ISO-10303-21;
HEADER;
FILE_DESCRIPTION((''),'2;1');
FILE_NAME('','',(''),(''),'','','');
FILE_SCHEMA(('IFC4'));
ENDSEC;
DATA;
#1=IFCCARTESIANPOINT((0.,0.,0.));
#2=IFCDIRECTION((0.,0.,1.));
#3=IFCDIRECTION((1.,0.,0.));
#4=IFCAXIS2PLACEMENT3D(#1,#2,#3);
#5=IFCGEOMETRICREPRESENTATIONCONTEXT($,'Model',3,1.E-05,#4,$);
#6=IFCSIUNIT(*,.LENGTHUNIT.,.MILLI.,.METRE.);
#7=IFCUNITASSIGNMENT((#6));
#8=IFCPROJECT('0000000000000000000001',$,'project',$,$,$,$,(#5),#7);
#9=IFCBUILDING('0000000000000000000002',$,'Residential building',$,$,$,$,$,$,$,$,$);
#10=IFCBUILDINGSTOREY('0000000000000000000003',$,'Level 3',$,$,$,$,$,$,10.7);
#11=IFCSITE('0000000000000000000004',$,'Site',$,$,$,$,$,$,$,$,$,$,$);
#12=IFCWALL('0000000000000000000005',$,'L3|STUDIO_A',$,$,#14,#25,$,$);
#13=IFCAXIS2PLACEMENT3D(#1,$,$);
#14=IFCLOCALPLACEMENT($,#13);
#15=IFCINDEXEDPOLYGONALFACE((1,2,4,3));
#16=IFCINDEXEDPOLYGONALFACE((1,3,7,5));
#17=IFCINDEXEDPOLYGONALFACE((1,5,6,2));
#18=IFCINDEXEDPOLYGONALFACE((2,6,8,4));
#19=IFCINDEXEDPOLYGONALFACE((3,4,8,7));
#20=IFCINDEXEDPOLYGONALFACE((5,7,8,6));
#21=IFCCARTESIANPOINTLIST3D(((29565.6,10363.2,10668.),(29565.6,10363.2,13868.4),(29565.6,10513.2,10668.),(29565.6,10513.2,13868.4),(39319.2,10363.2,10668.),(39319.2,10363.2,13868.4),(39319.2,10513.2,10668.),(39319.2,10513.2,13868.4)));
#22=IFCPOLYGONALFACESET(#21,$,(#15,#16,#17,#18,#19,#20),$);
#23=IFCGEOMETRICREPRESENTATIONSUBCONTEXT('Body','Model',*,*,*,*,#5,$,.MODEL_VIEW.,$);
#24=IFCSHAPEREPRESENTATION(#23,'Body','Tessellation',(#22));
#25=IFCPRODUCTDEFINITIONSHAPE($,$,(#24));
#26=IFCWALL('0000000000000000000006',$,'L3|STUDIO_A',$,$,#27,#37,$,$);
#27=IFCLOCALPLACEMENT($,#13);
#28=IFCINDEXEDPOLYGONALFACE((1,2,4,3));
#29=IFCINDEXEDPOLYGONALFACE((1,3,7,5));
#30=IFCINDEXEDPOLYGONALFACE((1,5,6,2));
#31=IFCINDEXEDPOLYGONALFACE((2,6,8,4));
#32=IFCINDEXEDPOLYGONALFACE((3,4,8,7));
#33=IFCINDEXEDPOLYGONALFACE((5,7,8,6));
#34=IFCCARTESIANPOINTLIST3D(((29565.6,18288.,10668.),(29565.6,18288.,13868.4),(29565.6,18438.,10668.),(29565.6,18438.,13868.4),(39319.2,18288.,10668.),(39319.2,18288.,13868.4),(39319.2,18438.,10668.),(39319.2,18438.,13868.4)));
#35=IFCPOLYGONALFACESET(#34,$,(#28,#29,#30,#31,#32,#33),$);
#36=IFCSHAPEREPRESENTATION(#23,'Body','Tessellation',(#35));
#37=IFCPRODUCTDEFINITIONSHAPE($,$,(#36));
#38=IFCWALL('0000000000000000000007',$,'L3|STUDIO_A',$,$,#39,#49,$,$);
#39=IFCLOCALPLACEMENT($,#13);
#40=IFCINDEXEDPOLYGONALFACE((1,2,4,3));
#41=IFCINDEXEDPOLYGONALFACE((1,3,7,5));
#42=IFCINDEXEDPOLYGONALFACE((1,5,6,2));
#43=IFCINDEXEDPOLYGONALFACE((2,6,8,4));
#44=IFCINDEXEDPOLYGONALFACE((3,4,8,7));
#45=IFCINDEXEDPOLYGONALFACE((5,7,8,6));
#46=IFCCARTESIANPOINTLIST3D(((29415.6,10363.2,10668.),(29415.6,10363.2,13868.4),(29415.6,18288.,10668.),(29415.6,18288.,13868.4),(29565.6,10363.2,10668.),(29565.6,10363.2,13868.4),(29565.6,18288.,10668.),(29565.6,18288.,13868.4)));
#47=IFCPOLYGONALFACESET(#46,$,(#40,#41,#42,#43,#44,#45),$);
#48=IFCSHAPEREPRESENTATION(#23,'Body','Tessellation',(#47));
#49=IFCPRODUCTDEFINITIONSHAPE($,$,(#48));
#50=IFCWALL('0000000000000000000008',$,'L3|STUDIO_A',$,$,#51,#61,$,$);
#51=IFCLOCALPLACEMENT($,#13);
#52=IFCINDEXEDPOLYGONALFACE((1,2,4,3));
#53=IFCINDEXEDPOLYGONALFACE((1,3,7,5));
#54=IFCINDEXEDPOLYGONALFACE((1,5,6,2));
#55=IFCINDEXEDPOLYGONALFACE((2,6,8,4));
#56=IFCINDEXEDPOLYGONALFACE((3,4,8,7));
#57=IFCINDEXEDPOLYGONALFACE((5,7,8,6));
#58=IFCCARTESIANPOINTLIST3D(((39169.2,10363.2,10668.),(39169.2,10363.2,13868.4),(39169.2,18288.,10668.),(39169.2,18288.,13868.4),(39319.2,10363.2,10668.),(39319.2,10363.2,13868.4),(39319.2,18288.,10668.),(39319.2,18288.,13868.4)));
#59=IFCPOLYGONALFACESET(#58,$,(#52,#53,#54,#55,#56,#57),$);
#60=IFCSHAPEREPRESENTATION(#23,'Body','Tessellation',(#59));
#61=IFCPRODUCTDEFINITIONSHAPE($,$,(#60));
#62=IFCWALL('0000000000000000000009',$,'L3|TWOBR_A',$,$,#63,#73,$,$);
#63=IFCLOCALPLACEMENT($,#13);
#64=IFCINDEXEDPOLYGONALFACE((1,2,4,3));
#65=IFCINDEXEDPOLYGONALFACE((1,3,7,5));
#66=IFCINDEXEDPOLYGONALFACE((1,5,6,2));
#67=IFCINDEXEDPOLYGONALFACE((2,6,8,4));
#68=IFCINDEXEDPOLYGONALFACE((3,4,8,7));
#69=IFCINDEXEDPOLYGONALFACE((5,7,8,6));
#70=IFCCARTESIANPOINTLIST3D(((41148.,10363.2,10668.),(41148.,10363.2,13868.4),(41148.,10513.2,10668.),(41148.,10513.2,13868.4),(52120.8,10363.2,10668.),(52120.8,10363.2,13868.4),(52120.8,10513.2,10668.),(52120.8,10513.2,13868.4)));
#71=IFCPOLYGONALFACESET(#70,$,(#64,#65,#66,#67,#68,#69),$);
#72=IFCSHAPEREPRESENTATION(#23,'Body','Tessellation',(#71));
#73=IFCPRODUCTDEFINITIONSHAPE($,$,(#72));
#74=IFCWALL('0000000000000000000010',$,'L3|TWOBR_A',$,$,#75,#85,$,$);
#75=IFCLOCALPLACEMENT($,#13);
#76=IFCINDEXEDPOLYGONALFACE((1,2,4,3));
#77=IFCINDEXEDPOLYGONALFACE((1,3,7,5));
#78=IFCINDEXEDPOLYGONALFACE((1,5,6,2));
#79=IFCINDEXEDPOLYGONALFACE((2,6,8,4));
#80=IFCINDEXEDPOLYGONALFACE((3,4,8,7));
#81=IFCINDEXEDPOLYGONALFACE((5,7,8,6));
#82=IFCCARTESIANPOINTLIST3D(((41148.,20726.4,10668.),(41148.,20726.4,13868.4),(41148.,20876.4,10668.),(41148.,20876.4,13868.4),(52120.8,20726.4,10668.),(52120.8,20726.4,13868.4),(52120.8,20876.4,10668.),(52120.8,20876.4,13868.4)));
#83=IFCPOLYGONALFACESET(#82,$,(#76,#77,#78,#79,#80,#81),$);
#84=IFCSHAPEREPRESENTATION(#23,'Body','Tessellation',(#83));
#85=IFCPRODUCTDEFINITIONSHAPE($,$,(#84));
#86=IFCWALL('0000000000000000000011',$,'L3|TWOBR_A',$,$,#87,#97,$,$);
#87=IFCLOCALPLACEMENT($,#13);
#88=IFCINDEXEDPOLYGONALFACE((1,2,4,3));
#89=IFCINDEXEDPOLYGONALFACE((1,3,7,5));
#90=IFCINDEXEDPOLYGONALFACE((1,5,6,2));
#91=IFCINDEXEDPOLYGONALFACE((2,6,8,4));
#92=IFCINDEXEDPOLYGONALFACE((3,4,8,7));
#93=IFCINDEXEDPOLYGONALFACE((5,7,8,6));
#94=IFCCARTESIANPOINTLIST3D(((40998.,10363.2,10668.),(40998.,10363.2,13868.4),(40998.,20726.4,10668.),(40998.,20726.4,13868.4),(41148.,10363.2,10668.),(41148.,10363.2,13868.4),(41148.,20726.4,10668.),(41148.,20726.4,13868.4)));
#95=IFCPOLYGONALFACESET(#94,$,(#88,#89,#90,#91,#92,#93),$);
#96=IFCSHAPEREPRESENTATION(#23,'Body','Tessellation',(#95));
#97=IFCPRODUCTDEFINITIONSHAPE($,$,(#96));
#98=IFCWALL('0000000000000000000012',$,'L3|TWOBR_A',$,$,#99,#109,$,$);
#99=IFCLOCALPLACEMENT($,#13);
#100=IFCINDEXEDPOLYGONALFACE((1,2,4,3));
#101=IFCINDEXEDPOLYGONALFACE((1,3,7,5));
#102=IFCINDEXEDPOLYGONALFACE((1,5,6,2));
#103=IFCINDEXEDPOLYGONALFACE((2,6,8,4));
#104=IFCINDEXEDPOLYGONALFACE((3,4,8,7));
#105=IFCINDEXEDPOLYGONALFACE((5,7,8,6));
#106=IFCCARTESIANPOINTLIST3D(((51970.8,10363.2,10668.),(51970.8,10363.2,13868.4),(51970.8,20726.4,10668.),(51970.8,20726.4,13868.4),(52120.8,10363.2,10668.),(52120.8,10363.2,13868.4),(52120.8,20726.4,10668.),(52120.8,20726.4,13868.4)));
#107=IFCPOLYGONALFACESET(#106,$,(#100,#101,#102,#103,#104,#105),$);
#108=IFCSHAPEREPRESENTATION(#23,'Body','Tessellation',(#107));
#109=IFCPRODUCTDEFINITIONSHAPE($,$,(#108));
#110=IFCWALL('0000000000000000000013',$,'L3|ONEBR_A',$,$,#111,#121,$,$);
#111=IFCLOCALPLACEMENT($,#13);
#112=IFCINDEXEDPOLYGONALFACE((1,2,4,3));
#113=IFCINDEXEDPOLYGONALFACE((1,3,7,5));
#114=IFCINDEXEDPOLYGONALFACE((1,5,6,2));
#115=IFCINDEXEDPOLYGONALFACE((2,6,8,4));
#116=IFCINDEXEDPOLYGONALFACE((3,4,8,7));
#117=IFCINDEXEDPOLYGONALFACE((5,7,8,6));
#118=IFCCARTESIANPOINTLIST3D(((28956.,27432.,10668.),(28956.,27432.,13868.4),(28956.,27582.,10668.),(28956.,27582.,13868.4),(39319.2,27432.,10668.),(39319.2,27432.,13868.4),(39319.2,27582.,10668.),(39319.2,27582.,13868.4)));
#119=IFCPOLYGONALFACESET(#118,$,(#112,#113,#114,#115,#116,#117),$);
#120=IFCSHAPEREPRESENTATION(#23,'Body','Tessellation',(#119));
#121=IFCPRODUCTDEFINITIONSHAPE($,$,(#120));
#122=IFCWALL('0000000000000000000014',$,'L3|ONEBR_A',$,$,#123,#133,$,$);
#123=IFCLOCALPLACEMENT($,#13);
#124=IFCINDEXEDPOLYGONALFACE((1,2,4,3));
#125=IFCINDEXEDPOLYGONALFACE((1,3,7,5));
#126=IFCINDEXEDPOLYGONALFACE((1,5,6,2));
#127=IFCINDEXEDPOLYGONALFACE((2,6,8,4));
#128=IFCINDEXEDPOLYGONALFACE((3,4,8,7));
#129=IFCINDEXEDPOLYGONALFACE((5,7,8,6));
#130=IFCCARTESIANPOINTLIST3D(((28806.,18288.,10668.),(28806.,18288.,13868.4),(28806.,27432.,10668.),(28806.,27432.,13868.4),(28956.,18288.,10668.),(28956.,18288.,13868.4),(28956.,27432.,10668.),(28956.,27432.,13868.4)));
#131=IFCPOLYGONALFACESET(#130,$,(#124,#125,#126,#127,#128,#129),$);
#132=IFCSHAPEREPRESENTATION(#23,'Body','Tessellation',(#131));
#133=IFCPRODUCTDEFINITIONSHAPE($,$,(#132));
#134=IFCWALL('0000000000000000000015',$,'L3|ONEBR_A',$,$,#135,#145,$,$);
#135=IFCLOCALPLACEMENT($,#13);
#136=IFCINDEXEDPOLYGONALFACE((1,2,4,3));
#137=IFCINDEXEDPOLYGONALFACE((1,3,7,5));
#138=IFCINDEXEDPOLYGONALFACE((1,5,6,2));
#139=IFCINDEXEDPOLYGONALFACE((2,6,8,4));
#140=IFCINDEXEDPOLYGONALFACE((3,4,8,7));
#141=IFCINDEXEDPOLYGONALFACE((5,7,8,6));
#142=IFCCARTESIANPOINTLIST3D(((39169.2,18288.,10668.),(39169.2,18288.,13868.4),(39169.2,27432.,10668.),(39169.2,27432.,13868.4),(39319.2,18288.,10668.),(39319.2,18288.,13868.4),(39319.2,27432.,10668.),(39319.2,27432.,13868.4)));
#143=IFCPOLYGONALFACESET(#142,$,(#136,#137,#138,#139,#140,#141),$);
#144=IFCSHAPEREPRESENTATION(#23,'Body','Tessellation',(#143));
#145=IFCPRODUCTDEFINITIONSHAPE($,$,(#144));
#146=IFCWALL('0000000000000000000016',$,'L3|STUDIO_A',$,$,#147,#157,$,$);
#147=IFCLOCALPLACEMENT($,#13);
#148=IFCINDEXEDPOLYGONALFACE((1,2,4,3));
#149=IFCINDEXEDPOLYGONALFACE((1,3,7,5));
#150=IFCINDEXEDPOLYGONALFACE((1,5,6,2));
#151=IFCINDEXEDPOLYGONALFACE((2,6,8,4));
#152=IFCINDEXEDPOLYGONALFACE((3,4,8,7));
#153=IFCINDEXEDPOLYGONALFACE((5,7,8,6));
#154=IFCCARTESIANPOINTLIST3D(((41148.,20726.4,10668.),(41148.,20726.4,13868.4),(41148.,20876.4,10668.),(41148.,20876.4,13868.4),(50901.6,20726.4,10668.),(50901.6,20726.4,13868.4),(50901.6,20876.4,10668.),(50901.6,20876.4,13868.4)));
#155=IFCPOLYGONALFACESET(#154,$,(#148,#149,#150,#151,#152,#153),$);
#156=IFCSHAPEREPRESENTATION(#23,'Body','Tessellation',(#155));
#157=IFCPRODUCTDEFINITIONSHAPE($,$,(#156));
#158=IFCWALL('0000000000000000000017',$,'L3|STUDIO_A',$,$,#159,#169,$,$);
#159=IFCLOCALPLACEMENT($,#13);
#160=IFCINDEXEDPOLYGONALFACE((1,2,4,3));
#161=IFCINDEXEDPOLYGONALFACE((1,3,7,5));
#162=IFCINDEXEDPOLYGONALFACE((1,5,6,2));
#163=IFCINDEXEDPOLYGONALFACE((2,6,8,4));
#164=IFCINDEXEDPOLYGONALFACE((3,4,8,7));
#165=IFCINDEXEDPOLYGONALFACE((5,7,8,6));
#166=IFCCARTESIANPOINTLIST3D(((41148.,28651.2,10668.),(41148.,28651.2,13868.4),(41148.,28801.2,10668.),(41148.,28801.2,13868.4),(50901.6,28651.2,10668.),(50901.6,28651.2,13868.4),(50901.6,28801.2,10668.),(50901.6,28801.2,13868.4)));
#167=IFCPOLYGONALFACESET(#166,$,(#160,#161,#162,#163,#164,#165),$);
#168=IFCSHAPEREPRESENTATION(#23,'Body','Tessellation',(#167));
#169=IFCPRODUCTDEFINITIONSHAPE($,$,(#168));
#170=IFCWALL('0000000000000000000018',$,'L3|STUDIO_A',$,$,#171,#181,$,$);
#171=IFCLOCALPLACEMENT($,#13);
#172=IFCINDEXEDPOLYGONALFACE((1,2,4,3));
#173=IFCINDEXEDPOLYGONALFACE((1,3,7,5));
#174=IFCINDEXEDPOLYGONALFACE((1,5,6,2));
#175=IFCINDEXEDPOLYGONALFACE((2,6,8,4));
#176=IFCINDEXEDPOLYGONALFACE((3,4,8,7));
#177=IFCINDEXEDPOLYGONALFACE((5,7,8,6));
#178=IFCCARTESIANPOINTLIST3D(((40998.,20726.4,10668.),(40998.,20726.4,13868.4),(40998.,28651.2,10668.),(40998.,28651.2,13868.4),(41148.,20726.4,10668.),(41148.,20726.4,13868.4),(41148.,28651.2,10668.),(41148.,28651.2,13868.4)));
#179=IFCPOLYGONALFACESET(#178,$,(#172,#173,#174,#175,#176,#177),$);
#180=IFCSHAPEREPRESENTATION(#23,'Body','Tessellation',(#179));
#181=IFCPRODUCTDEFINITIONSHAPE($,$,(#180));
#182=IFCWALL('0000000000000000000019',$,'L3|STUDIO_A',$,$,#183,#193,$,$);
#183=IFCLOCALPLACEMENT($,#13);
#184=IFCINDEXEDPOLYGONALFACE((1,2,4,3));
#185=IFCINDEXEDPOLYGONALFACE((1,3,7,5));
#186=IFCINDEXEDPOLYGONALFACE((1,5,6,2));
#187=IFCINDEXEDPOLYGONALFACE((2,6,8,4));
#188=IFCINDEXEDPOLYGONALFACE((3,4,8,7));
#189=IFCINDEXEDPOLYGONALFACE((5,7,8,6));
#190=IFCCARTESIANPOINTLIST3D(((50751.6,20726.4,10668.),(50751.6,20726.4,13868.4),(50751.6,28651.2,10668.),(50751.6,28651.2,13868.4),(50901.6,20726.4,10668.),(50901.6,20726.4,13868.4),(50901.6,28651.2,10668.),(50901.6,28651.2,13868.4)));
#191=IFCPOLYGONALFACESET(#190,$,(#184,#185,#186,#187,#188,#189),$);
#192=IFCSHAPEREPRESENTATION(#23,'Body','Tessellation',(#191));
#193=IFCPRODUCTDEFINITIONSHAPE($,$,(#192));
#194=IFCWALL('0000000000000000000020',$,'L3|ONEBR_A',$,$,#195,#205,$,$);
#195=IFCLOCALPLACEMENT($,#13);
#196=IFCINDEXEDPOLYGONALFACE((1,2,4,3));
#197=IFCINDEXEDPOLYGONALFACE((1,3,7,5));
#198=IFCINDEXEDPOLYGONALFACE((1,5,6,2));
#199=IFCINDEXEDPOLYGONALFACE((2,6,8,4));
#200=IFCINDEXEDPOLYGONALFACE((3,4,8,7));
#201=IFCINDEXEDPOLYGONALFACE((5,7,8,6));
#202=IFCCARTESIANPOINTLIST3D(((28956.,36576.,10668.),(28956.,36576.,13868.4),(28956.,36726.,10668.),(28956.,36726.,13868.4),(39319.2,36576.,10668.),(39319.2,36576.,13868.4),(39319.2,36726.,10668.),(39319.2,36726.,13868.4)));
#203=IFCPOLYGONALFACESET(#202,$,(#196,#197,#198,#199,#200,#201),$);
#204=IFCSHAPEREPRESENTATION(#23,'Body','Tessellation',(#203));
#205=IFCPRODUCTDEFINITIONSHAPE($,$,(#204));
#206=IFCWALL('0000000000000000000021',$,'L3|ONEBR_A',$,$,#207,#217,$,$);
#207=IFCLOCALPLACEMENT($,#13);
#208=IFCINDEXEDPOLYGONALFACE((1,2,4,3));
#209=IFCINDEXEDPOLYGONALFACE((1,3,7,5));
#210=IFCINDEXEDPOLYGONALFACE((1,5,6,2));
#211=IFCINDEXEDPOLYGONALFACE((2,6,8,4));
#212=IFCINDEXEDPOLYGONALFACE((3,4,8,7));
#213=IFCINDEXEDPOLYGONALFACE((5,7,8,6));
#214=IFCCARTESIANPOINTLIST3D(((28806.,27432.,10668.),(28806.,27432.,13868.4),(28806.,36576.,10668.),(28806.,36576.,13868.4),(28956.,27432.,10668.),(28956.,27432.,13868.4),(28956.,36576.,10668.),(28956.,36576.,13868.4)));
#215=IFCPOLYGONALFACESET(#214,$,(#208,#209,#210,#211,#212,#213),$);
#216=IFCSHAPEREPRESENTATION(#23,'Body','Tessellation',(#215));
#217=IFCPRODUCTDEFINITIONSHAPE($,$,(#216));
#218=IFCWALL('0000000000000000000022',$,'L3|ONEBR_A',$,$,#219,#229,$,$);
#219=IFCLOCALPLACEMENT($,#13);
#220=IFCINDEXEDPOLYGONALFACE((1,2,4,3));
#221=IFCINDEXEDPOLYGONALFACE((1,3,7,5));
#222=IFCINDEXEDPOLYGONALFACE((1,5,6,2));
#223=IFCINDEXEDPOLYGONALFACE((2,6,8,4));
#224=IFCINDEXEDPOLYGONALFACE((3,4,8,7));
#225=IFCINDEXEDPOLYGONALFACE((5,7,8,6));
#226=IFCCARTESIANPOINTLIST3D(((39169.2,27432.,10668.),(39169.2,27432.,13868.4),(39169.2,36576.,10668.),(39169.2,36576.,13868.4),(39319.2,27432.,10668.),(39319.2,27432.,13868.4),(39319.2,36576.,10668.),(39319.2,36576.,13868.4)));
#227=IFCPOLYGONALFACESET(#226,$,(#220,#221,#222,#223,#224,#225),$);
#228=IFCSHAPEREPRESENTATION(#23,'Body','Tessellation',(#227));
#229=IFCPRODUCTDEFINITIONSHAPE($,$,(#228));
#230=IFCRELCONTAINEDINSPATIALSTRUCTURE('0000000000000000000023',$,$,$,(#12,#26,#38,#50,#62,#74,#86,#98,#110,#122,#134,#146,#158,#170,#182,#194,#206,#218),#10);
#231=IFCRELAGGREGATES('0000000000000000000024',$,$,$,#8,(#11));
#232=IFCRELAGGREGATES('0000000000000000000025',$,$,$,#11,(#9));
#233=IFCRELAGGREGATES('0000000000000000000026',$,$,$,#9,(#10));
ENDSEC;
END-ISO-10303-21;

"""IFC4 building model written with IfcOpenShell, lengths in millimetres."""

from ifc_helpers import new_model, si_unit, frame, origin_with_axes, place, context, subcontext, project, spatial, indexed_curve, outline, extrude, element, save


model = new_model("IFC4")

# Units and contexts
model_context = context("Model", 3, precision=1e-05, world=origin_with_axes())
body_context = subcontext(model_context, "Body", "Model", "MODEL_VIEW")
ifc_project = project(units=[si_unit("LENGTHUNIT", "METRE", prefix="MILLI")], contexts=[model_context])

# Site, building, storey
site = spatial("IfcSite", under=ifc_project, Name="Site")
building = spatial("IfcBuilding", under=site, Name="Residential building")
storey = spatial("IfcBuildingStorey", under=building, Name="Level 3", Elevation=10.7)

# Walls
for number, where, z_axis, x_axis, name in (
    (1, (29565.6, 10363.2, 10668.0), (0.0, 0.0, 1.0), (1.0, 0.0, 0.0), "L3|STUDIO_A"),
    (2, (29565.6, 18288.0, 10668.0), (0.0, 0.0, 1.0), (1.0, 0.0, 0.0), "L3|STUDIO_A"),
):
    element("IfcWall", number, at=place(None, frame(where, z_axis=z_axis, x_axis=x_axis)), inside=storey, Name=name, context=body_context, shape_type="SweptSolid", body=[
        extrude(outline(indexed_curve([(0.0, 0.0), (0.0, 150.0), (9753.6, 150.0), (9753.6, 0.0), (0.0, 0.0)], self_intersect=False)), origin_with_axes(), (0.0, 0.0, 1.0), 3200.4),
    ])
for number, where, z_axis, x_axis, name in (
    (3, (29565.6, 10363.2, 10668.0), (0.0, 0.0, 1.0), (0.0, 1.0, 0.0), "L3|STUDIO_A"),
    (4, (39319.2, 10363.2, 10668.0), (0.0, 0.0, 1.0), (0.0, 1.0, 0.0), "L3|STUDIO_A"),
):
    element("IfcWall", number, at=place(None, frame(where, z_axis=z_axis, x_axis=x_axis)), inside=storey, Name=name, context=body_context, shape_type="SweptSolid", body=[
        extrude(outline(indexed_curve([(0.0, 0.0), (0.0, 150.0), (7924.8, 150.0), (7924.8, 0.0), (0.0, 0.0)], self_intersect=False)), origin_with_axes(), (0.0, 0.0, 1.0), 3200.4),
    ])
for number, where, z_axis, x_axis, name in (
    (5, (41148.0, 10363.2, 10668.0), (0.0, 0.0, 1.0), (1.0, 0.0, 0.0), "L3|TWOBR_A"),
    (6, (41148.0, 20726.4, 10668.0), (0.0, 0.0, 1.0), (1.0, 0.0, 0.0), "L3|TWOBR_A"),
):
    element("IfcWall", number, at=place(None, frame(where, z_axis=z_axis, x_axis=x_axis)), inside=storey, Name=name, context=body_context, shape_type="SweptSolid", body=[
        extrude(outline(indexed_curve([(0.0, 0.0), (0.0, 150.0), (10972.8, 150.0), (10972.8, 0.0), (0.0, 0.0)], self_intersect=False)), origin_with_axes(), (0.0, 0.0, 1.0), 3200.4),
    ])
for number, where, z_axis, x_axis, name in (
    (7, (41148.0, 10363.2, 10668.0), (0.0, 0.0, 1.0), (0.0, 1.0, 0.0), "L3|TWOBR_A"),
    (8, (52120.8, 10363.2, 10668.0), (0.0, 0.0, 1.0), (0.0, 1.0, 0.0), "L3|TWOBR_A"),
    (9, (28956.0, 27432.0, 10668.0), (0.0, 0.0, 1.0), (1.0, 0.0, 0.0), "L3|ONEBR_A"),
):
    element("IfcWall", number, at=place(None, frame(where, z_axis=z_axis, x_axis=x_axis)), inside=storey, Name=name, context=body_context, shape_type="SweptSolid", body=[
        extrude(outline(indexed_curve([(0.0, 0.0), (0.0, 150.0), (10363.2, 150.0), (10363.2, 0.0), (0.0, 0.0)], self_intersect=False)), origin_with_axes(), (0.0, 0.0, 1.0), 3200.4),
    ])
for number, where, z_axis, x_axis, name in (
    (10, (28956.0, 18288.0, 10668.0), (0.0, 0.0, 1.0), (0.0, 1.0, 0.0), "L3|ONEBR_A"),
    (11, (39319.2, 18288.0, 10668.0), (0.0, 0.0, 1.0), (0.0, 1.0, 0.0), "L3|ONEBR_A"),
):
    element("IfcWall", number, at=place(None, frame(where, z_axis=z_axis, x_axis=x_axis)), inside=storey, Name=name, context=body_context, shape_type="SweptSolid", body=[
        extrude(outline(indexed_curve([(0.0, 0.0), (0.0, 150.0), (9144.0, 150.0), (9144.0, 0.0), (0.0, 0.0)], self_intersect=False)), origin_with_axes(), (0.0, 0.0, 1.0), 3200.4),
    ])
for number, where, z_axis, x_axis, name in (
    (12, (41148.0, 20726.4, 10668.0), (0.0, 0.0, 1.0), (1.0, 0.0, 0.0), "L3|STUDIO_A"),
    (13, (41148.0, 28651.2, 10668.0), (0.0, 0.0, 1.0), (1.0, 0.0, 0.0), "L3|STUDIO_A"),
):
    element("IfcWall", number, at=place(None, frame(where, z_axis=z_axis, x_axis=x_axis)), inside=storey, Name=name, context=body_context, shape_type="SweptSolid", body=[
        extrude(outline(indexed_curve([(0.0, 0.0), (0.0, 150.0), (9753.6, 150.0), (9753.6, 0.0), (0.0, 0.0)], self_intersect=False)), origin_with_axes(), (0.0, 0.0, 1.0), 3200.4),
    ])
for number, where, z_axis, x_axis, name in (
    (14, (41148.0, 20726.4, 10668.0), (0.0, 0.0, 1.0), (0.0, 1.0, 0.0), "L3|STUDIO_A"),
    (15, (50901.6, 20726.4, 10668.0), (0.0, 0.0, 1.0), (0.0, 1.0, 0.0), "L3|STUDIO_A"),
):
    element("IfcWall", number, at=place(None, frame(where, z_axis=z_axis, x_axis=x_axis)), inside=storey, Name=name, context=body_context, shape_type="SweptSolid", body=[
        extrude(outline(indexed_curve([(0.0, 0.0), (0.0, 150.0), (7924.8, 150.0), (7924.8, 0.0), (0.0, 0.0)], self_intersect=False)), origin_with_axes(), (0.0, 0.0, 1.0), 3200.4),
    ])
for number, where, z_axis, x_axis, name in (
    (16, (28956.0, 36576.0, 10668.0), (0.0, 0.0, 1.0), (1.0, 0.0, 0.0), "L3|ONEBR_A"),
):
    element("IfcWall", number, at=place(None, frame(where, z_axis=z_axis, x_axis=x_axis)), inside=storey, Name=name, context=body_context, shape_type="SweptSolid", body=[
        extrude(outline(indexed_curve([(0.0, 0.0), (0.0, 150.0), (10363.2, 150.0), (10363.2, 0.0), (0.0, 0.0)], self_intersect=False)), origin_with_axes(), (0.0, 0.0, 1.0), 3200.4),
    ])
for number, where, z_axis, x_axis, name in (
    (17, (28956.0, 27432.0, 10668.0), (0.0, 0.0, 1.0), (0.0, 1.0, 0.0), "L3|ONEBR_A"),
    (18, (39319.2, 27432.0, 10668.0), (0.0, 0.0, 1.0), (0.0, 1.0, 0.0), "L3|ONEBR_A"),
):
    element("IfcWall", number, at=place(None, frame(where, z_axis=z_axis, x_axis=x_axis)), inside=storey, Name=name, context=body_context, shape_type="SweptSolid", body=[
        extrude(outline(indexed_curve([(0.0, 0.0), (0.0, 150.0), (9144.0, 150.0), (9144.0, 0.0), (0.0, 0.0)], self_intersect=False)), origin_with_axes(), (0.0, 0.0, 1.0), 3200.4),
    ])

save(model, "model.ifc")
